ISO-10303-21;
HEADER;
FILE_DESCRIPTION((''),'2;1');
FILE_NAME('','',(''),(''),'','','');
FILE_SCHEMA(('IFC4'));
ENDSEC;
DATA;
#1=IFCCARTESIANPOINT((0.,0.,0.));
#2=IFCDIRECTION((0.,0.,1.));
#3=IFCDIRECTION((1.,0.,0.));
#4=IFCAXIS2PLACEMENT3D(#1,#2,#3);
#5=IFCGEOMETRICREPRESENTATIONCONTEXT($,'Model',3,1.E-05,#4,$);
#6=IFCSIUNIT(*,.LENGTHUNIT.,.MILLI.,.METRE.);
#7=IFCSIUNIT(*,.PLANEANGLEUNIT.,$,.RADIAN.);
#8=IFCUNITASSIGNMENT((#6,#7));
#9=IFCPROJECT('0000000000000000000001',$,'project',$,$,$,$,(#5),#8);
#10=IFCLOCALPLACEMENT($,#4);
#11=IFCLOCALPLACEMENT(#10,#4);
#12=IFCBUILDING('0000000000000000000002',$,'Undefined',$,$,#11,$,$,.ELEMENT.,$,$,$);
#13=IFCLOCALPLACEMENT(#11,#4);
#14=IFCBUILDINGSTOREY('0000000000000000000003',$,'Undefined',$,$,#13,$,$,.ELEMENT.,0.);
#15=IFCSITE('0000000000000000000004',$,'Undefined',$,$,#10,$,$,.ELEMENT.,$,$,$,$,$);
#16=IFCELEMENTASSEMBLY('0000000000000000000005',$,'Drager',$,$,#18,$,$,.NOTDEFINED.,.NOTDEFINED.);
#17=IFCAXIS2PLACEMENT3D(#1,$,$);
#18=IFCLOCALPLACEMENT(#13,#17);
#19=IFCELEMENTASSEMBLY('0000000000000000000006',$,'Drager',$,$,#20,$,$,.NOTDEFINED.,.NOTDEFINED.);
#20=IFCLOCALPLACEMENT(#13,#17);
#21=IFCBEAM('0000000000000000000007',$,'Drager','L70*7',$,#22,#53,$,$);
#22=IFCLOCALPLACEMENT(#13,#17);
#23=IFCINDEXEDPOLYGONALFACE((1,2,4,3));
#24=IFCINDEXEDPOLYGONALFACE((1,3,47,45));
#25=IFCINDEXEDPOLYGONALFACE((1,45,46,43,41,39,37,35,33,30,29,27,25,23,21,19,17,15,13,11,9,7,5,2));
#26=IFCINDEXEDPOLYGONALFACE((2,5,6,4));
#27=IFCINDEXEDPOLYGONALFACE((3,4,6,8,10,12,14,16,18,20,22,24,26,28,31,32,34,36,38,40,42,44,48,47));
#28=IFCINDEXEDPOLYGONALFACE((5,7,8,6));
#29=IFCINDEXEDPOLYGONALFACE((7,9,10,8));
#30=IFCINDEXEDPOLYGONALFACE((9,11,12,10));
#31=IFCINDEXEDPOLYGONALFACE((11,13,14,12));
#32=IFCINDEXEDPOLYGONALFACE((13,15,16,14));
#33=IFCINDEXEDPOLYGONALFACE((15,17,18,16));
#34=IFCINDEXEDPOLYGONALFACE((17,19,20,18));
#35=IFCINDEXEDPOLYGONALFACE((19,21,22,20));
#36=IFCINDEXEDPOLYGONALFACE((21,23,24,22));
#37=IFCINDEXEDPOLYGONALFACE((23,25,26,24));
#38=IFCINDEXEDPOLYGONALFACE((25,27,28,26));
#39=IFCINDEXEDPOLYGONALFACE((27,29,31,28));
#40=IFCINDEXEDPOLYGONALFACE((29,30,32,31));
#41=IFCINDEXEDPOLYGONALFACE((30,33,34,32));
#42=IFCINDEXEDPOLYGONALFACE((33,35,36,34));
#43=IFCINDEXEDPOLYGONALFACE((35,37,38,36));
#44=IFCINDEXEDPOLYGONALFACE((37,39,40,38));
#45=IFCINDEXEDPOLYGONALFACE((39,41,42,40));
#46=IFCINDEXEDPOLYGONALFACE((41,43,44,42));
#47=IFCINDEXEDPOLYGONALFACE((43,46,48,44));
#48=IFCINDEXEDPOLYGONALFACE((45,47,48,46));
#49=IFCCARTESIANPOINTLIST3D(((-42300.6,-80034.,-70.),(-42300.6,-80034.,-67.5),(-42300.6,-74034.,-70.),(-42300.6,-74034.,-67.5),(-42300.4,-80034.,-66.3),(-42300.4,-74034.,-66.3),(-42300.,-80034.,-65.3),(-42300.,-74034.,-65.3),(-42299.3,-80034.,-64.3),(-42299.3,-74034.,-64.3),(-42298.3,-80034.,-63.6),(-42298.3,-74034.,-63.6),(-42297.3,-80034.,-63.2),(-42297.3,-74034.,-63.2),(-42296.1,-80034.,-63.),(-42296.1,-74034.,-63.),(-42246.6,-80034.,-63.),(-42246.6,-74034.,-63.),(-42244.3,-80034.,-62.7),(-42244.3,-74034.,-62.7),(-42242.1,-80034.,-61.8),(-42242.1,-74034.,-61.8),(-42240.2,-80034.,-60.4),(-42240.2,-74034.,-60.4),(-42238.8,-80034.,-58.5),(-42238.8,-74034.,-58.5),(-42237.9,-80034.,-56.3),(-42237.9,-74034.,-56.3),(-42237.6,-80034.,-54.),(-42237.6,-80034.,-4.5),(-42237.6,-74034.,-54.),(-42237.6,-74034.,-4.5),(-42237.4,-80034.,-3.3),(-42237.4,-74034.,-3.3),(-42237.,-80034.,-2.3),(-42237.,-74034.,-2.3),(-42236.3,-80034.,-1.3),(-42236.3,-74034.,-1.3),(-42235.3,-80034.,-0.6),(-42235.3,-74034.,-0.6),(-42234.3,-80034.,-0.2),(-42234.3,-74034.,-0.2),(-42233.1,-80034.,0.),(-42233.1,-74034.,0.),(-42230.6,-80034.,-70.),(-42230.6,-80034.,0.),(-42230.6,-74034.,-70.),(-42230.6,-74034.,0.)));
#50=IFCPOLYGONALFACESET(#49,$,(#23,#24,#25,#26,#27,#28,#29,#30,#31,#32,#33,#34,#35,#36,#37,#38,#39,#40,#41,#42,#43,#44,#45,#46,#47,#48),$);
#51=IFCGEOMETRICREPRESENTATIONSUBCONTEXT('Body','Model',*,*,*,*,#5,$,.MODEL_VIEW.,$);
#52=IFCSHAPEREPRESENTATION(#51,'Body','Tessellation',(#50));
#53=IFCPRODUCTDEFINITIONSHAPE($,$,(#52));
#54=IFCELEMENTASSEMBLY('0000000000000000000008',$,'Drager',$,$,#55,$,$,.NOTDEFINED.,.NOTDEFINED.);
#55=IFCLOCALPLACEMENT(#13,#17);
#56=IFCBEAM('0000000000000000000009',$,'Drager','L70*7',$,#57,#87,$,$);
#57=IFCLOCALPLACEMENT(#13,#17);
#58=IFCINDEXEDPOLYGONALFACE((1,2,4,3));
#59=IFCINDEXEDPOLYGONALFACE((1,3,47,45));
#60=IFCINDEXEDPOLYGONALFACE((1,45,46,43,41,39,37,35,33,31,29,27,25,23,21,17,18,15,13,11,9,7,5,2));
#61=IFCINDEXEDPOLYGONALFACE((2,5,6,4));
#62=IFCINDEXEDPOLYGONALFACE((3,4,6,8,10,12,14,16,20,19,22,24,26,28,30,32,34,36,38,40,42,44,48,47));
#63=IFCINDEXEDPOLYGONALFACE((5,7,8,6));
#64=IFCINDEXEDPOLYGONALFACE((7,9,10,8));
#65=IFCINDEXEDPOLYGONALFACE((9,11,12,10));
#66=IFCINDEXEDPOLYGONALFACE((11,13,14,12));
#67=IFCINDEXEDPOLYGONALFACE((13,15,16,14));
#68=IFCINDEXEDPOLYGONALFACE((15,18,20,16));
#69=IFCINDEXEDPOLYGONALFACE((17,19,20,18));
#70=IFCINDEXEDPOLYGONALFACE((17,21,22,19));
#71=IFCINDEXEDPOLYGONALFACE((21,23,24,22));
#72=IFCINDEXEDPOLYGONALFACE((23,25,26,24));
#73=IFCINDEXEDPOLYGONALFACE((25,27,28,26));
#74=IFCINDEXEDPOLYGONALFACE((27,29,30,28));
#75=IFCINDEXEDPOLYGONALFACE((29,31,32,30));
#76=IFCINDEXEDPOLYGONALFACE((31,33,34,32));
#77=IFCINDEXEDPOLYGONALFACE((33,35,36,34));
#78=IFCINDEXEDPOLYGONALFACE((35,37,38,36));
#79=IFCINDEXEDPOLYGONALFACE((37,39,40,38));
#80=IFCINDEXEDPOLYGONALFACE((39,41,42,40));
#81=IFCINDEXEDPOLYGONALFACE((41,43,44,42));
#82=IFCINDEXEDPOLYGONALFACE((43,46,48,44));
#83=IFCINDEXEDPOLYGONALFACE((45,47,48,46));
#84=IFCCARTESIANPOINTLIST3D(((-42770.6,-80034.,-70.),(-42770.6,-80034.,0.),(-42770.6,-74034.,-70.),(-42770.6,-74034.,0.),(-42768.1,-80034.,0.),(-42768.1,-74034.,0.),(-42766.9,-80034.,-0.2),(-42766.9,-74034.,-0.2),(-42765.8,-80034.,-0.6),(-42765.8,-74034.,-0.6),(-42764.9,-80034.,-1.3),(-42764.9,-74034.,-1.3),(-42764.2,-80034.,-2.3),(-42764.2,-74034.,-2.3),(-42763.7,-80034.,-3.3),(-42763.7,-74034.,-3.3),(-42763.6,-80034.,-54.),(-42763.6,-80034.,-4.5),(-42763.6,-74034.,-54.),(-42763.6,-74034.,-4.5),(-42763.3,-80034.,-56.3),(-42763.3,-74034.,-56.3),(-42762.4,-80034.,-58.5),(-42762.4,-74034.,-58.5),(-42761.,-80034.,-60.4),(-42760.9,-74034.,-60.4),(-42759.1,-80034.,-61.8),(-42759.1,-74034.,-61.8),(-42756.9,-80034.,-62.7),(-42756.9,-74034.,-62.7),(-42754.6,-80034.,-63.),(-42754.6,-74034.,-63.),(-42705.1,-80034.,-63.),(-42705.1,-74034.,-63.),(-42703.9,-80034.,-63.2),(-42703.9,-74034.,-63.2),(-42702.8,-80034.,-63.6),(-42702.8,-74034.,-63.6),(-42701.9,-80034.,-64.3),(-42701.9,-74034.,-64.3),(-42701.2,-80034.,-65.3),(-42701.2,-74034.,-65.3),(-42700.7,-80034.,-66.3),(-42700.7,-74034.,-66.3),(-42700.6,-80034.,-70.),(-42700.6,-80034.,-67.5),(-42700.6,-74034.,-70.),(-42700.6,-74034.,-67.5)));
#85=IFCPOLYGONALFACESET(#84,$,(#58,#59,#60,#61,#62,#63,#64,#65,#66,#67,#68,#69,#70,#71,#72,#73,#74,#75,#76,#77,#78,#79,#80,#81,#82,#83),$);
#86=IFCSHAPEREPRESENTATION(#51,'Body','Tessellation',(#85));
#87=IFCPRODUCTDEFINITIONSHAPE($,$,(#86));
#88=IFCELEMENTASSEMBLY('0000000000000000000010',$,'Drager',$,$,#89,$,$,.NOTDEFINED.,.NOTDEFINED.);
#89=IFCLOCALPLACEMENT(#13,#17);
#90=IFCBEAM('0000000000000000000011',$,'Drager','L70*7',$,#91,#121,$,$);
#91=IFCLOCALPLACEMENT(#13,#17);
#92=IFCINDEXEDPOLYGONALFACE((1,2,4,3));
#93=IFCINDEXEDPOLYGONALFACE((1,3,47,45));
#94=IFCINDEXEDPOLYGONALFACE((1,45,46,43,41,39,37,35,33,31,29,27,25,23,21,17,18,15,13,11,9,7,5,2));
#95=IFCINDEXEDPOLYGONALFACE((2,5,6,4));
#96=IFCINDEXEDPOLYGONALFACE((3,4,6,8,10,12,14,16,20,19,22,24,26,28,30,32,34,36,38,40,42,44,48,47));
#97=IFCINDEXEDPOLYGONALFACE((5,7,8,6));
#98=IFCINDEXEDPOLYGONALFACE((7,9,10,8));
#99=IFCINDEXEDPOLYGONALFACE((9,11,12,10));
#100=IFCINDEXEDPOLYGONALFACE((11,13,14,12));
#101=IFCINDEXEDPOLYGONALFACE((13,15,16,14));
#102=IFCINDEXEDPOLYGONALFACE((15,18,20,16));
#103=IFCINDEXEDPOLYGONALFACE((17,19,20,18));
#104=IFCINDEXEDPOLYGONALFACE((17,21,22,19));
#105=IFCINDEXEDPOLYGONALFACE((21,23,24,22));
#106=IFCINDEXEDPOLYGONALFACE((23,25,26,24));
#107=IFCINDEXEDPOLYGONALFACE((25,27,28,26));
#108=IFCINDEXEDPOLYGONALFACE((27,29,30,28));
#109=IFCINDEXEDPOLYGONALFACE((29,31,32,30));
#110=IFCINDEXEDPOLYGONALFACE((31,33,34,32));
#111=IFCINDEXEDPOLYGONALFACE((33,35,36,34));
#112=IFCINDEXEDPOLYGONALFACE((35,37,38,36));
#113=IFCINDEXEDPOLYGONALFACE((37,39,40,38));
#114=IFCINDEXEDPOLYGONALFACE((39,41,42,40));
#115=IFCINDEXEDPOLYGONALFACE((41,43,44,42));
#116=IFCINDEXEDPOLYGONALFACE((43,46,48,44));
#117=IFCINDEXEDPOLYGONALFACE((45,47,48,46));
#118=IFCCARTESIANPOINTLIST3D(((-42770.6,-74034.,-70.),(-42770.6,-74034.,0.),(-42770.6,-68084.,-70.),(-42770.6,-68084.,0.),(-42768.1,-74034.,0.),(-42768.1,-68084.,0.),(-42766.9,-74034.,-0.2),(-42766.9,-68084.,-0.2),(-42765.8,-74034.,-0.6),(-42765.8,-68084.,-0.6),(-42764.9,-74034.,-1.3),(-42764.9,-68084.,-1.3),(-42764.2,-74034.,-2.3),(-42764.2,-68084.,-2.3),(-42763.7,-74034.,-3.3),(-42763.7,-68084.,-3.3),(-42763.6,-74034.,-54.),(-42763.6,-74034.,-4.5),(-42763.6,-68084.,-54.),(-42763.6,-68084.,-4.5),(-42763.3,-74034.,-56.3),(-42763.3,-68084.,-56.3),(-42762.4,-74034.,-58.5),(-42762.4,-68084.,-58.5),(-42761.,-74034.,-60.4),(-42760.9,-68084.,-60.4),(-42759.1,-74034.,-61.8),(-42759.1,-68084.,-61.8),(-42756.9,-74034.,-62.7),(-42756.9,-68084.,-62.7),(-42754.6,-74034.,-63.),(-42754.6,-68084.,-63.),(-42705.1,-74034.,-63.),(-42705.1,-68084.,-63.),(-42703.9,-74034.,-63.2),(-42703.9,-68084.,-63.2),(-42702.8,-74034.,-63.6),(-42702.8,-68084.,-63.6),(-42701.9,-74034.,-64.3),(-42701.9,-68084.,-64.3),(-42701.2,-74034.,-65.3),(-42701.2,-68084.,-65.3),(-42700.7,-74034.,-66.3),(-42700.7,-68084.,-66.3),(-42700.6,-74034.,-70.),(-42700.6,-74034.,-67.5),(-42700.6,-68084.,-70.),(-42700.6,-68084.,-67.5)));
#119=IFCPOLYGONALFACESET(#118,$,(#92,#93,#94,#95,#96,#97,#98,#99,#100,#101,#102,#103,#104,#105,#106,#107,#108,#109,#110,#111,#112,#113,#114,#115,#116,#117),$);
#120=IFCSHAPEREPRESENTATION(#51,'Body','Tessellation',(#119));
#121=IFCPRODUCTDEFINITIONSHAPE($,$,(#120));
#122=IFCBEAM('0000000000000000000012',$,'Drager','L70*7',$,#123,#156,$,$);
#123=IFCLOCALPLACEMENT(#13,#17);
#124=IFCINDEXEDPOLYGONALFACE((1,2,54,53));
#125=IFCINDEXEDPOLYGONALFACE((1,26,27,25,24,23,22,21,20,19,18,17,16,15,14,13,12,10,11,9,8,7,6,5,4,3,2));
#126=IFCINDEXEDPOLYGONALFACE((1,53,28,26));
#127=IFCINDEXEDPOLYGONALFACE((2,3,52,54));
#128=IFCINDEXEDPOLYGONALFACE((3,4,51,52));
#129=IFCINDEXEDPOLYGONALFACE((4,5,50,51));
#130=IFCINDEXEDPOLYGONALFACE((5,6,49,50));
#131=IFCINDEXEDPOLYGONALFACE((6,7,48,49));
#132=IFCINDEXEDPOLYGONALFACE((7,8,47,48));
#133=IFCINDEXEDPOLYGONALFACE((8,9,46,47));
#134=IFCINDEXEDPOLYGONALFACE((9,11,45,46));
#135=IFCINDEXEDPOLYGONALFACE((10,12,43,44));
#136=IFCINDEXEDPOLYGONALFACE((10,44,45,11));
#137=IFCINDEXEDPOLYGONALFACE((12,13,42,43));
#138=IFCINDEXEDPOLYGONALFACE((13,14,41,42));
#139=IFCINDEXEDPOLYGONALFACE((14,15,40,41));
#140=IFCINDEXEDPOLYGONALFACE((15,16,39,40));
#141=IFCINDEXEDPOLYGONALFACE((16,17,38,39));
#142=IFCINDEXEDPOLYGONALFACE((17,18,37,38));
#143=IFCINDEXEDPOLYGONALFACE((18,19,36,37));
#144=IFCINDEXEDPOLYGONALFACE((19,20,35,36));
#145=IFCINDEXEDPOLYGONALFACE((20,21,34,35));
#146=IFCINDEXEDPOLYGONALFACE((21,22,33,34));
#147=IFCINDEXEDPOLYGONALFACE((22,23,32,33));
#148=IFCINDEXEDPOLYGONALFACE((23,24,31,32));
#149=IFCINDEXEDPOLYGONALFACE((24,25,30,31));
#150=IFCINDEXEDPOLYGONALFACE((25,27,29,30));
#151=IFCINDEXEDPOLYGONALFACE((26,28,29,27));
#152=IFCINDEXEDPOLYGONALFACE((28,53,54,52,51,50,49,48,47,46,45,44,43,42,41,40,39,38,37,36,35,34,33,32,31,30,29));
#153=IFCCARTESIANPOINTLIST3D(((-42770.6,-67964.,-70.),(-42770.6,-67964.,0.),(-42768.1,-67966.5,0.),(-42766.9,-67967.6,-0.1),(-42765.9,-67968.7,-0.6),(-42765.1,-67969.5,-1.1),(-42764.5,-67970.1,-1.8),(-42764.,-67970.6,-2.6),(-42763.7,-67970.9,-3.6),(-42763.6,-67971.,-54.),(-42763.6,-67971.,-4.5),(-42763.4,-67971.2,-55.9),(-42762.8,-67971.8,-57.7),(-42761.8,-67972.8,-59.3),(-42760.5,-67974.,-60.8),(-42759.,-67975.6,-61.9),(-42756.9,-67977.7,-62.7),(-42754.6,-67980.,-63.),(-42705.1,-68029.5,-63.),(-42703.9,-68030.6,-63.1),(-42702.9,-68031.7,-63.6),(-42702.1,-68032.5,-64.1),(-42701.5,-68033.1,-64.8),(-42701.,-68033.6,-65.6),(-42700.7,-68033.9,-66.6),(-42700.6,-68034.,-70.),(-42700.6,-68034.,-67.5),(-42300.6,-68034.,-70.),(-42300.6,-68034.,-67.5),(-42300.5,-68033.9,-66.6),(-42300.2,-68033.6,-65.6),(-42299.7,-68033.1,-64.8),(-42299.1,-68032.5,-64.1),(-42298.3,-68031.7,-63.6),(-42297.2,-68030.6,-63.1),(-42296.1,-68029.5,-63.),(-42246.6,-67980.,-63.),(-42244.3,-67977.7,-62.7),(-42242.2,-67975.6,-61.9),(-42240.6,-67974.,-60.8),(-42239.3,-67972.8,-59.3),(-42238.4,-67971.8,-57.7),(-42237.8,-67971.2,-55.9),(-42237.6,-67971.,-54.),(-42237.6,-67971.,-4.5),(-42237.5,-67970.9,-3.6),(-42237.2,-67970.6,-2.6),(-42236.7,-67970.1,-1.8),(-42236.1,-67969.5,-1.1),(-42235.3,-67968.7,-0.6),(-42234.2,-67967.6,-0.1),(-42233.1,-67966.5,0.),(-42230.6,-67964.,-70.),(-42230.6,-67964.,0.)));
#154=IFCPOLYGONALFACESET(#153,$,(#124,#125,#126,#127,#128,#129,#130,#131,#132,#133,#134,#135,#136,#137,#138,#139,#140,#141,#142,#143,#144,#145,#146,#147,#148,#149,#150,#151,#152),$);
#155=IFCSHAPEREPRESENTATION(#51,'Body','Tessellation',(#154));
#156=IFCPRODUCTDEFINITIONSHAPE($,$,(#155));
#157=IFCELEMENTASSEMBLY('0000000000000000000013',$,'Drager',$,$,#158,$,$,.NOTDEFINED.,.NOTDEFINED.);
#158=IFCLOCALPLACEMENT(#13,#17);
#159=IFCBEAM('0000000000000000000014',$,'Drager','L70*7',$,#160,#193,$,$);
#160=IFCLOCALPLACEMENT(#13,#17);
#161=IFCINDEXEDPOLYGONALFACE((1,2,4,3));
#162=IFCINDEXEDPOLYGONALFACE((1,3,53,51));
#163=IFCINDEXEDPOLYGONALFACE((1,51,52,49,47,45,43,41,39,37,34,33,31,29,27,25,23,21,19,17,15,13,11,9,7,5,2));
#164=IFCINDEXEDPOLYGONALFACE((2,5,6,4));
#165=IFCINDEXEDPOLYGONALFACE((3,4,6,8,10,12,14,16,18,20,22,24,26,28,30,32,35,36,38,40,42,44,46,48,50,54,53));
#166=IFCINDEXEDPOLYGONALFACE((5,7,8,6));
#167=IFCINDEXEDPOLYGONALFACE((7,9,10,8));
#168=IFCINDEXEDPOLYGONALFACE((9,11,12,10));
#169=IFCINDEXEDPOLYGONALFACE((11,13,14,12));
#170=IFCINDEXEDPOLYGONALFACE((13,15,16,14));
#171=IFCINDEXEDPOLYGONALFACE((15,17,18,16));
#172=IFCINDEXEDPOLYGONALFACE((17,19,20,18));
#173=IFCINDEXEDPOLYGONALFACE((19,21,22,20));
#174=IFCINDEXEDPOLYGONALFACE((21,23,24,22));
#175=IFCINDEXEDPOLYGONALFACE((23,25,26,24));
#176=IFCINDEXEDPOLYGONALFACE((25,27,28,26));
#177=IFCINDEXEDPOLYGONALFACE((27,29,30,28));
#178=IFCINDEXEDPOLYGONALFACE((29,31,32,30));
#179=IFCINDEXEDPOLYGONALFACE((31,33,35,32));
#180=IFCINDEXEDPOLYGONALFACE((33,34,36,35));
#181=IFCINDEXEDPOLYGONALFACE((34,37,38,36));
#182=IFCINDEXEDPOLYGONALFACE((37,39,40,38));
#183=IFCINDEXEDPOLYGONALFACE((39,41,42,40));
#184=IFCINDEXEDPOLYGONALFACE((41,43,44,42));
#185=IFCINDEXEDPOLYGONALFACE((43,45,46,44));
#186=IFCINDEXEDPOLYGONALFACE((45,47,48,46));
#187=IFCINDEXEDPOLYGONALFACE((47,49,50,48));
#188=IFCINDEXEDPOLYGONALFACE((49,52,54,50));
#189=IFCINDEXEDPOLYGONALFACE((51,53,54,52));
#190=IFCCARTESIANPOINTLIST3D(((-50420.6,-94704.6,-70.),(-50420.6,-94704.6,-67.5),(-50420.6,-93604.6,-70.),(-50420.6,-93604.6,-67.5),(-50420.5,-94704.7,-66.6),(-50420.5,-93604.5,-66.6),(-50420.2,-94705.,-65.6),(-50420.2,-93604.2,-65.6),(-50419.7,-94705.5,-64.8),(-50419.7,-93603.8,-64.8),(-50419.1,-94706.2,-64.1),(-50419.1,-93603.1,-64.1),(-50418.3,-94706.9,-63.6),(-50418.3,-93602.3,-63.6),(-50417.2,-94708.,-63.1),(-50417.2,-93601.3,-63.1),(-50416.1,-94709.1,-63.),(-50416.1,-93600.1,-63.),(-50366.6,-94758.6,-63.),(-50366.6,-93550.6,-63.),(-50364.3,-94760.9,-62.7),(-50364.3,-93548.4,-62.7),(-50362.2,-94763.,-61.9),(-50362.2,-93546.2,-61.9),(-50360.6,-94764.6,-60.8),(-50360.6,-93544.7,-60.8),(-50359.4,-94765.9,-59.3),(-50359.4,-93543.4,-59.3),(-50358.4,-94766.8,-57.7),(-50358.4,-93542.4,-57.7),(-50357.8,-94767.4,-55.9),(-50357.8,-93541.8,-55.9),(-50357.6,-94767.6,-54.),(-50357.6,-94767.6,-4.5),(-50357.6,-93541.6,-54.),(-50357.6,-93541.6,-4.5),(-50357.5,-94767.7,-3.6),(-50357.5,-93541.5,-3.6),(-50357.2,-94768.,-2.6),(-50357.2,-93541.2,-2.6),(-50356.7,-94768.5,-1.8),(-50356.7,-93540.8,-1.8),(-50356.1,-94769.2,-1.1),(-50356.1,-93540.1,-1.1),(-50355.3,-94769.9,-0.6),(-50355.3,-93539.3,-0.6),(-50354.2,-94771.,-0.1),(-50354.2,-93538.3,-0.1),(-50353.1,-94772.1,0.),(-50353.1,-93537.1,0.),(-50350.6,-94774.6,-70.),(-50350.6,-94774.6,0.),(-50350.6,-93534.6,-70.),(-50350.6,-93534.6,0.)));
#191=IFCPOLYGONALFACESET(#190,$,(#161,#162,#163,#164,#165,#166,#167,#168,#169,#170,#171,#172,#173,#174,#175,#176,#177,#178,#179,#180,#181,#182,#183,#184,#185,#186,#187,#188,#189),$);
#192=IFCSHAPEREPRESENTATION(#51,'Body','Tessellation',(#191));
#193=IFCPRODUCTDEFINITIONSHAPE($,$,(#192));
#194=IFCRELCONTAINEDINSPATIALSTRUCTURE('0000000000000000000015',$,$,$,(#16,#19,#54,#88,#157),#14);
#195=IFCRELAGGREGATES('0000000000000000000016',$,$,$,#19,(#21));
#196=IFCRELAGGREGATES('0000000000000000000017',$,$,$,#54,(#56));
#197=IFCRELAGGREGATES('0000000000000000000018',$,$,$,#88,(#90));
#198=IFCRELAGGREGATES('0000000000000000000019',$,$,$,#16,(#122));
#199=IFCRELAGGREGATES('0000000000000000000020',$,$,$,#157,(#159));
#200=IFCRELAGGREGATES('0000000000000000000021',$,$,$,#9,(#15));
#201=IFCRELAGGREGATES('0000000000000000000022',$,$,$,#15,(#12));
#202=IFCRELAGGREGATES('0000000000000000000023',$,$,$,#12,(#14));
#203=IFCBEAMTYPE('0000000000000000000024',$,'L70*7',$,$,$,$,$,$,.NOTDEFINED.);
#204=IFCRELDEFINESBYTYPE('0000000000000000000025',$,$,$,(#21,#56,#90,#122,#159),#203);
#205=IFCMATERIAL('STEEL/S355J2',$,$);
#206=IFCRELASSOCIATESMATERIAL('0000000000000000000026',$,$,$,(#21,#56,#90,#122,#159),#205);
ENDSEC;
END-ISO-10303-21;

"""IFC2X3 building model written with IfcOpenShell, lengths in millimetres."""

from ifc_helpers import new_model, si_unit, frame, origin_with_axes, origin_2d_with_axis, place, context, subcontext, project, spatial, l_section, extrude, clip, halfspace, material, type_object, element, aggregate, save


model = new_model("IFC2X3")

# Units and contexts
model_context = context("Model", 3, precision=1e-05, world=origin_with_axes())
body_context = subcontext(model_context, "Body", "Model", "MODEL_VIEW")
ifc_project = project(units=[si_unit("LENGTHUNIT", "METRE", prefix="MILLI"), si_unit("PLANEANGLEUNIT", "RADIAN")], contexts=[model_context])

# Site, building, storey
site_placement = place(None, origin_with_axes())
site = spatial("IfcSite", under=ifc_project, at=site_placement, Name="Undefined", CompositionType="ELEMENT")
building_placement = place(site_placement, origin_with_axes())
building = spatial("IfcBuilding", under=site, at=building_placement, Name="Undefined", CompositionType="ELEMENT")
storey_placement = place(building_placement, origin_with_axes())
storey = spatial("IfcBuildingStorey", under=building, at=storey_placement, Name="Undefined", CompositionType="ELEMENT", Elevation=0.0)

# Element assembly
ifc_material_1 = material(Name="STEEL/S355J2")
beam_type_1 = type_object("IfcBeamType", Name="L70*7", PredefinedType="NOTDEFINED")
assembly_1_placement = place(storey_placement, origin_with_axes())
assembly_1 = element("IfcElementAssembly", 1, at=assembly_1_placement, inside=storey, Name="Drager", AssemblyPlace="NOTDEFINED", PredefinedType="NOTDEFINED")

# Element assemblies, beams
assembly_2_placement = place(storey_placement, origin_with_axes())
assembly_2 = element("IfcElementAssembly", 2, at=assembly_2_placement, inside=storey, Name="Drager", AssemblyPlace="NOTDEFINED", PredefinedType="NOTDEFINED")
beam_1_placement = place(assembly_2_placement, frame((-42265.6, -74034.0, -35.0), z_axis=(0.0, 0.0, 1.0), x_axis=(0.0, -1.0, 0.0)))
beam_1 = element("IfcBeam", 3, at=beam_1_placement, type_object=beam_type_1, material=ifc_material_1, Name="Drager", Description="L70*7", context=body_context, shape_type="SweptSolid", body=[
    extrude(l_section(Depth=70.0, Width=70.0, Thickness=7.0, FilletRadius=9.0, EdgeRadius=4.5, at=origin_2d_with_axis()), frame((6000.0, 0.0, 0.0), z_axis=(-1.0, 0.0, 0.0), x_axis=(0.0, -1.0, 0.0)), (0.0, 0.0, 1.0), 6000.0),
])
aggregate(assembly_2, [beam_1])
assembly_3_placement = place(storey_placement, origin_with_axes())
assembly_3 = element("IfcElementAssembly", 4, at=assembly_3_placement, inside=storey, Name="Drager", AssemblyPlace="NOTDEFINED", PredefinedType="NOTDEFINED")
beam_2_placement = place(assembly_3_placement, frame((-42735.6, -80034.0, -35.0), z_axis=(0.0, 0.0, 1.0), x_axis=(0.0, 1.0, 0.0)))
beam_2 = element("IfcBeam", 5, at=beam_2_placement, type_object=beam_type_1, material=ifc_material_1, Name="Drager", Description="L70*7", context=body_context, shape_type="SweptSolid", body=[
    extrude(l_section(Depth=70.0, Width=70.0, Thickness=7.0, FilletRadius=9.0, EdgeRadius=4.5, at=origin_2d_with_axis()), frame((6000.0, 0.0, 0.0), z_axis=(-1.0, 0.0, 0.0), x_axis=(0.0, -1.0, 0.0)), (0.0, 0.0, 1.0), 6000.0),
])
aggregate(assembly_3, [beam_2])
assembly_4_placement = place(storey_placement, origin_with_axes())
assembly_4 = element("IfcElementAssembly", 6, at=assembly_4_placement, inside=storey, Name="Drager", AssemblyPlace="NOTDEFINED", PredefinedType="NOTDEFINED")
beam_3_placement = place(assembly_4_placement, frame((-42735.6, -74034.0, -35.0), z_axis=(0.0, 0.0, 1.0), x_axis=(0.0, 1.0, 0.0)))
beam_3 = element("IfcBeam", 7, at=beam_3_placement, type_object=beam_type_1, material=ifc_material_1, Name="Drager", Description="L70*7", context=body_context, shape_type="SweptSolid", body=[
    extrude(l_section(Depth=70.0, Width=70.0, Thickness=7.0, FilletRadius=9.0, EdgeRadius=4.5, at=origin_2d_with_axis()), frame((5950.0, 0.0, 0.0), z_axis=(-1.0, 0.0, 0.0), x_axis=(0.0, -1.0, 0.0)), (0.0, 0.0, 1.0), 5950.0),
])
aggregate(assembly_4, [beam_3])

# Beam
beam_4_placement = place(assembly_1_placement, frame((-42700.6, -67999.0, -35.0), z_axis=(0.0, 0.0, 1.0), x_axis=(1.0, 0.0, 0.0)))
beam_4 = element("IfcBeam", 8, at=beam_4_placement, type_object=beam_type_1, material=ifc_material_1, Name="Drager", Description="L70*7", context=body_context, shape_type="Clipping", body=[
    clip(clip(extrude(l_section(Depth=70.0, Width=70.0, Thickness=7.0, FilletRadius=9.0, EdgeRadius=4.5, at=origin_2d_with_axis()), frame((505.7, 0.0, 0.0), z_axis=(-1.0, 0.0, 0.0), x_axis=(0.0, -1.0, 0.0)), (0.0, 0.0, 1.0), 611.4), halfspace(frame((400.0, -35.0, 35.0), z_axis=(-0.707107, 0.707107, 0.0), x_axis=(0.707107, 0.707107, 0.0)), True)), halfspace(frame((0.0, -35.0, 35.0), z_axis=(-0.707107, -0.707107, 0.0), x_axis=(-0.707107, 0.707107, 0.0)), False)),
])
aggregate(assembly_1, [beam_4])

# Element assembly, beam
assembly_5_placement = place(storey_placement, origin_with_axes())
assembly_5 = element("IfcElementAssembly", 9, at=assembly_5_placement, inside=storey, Name="Drager", AssemblyPlace="NOTDEFINED", PredefinedType="NOTDEFINED")
beam_5_placement = place(assembly_5_placement, frame((-50385.6, -93604.6, -35.0), z_axis=(0.0, 0.0, 1.0), x_axis=(0.0, -1.0, 0.0)))
beam_5 = element("IfcBeam", 10, at=beam_5_placement, type_object=beam_type_1, material=ifc_material_1, Name="Drager", Description="L70*7", context=body_context, shape_type="Clipping", body=[
    clip(clip(extrude(l_section(Depth=70.0, Width=70.0, Thickness=7.0, FilletRadius=9.0, EdgeRadius=4.5, at=origin_2d_with_axis()), frame((1205.7, 0.0, 0.0), z_axis=(-1.0, 0.0, 0.0), x_axis=(0.0, -1.0, 0.0)), (0.0, 0.0, 1.0), 1311.4), halfspace(frame((1100.0, -35.0, 35.0), z_axis=(-0.707107, 0.707107, 0.0), x_axis=(0.707107, 0.707107, 0.0)), True)), halfspace(frame((0.0, -35.0, 35.0), z_axis=(-0.707107, -0.707107, 0.0), x_axis=(-0.707107, 0.707107, 0.0)), False)),
])
aggregate(assembly_5, [beam_5])

save(model, "model.ifc")
